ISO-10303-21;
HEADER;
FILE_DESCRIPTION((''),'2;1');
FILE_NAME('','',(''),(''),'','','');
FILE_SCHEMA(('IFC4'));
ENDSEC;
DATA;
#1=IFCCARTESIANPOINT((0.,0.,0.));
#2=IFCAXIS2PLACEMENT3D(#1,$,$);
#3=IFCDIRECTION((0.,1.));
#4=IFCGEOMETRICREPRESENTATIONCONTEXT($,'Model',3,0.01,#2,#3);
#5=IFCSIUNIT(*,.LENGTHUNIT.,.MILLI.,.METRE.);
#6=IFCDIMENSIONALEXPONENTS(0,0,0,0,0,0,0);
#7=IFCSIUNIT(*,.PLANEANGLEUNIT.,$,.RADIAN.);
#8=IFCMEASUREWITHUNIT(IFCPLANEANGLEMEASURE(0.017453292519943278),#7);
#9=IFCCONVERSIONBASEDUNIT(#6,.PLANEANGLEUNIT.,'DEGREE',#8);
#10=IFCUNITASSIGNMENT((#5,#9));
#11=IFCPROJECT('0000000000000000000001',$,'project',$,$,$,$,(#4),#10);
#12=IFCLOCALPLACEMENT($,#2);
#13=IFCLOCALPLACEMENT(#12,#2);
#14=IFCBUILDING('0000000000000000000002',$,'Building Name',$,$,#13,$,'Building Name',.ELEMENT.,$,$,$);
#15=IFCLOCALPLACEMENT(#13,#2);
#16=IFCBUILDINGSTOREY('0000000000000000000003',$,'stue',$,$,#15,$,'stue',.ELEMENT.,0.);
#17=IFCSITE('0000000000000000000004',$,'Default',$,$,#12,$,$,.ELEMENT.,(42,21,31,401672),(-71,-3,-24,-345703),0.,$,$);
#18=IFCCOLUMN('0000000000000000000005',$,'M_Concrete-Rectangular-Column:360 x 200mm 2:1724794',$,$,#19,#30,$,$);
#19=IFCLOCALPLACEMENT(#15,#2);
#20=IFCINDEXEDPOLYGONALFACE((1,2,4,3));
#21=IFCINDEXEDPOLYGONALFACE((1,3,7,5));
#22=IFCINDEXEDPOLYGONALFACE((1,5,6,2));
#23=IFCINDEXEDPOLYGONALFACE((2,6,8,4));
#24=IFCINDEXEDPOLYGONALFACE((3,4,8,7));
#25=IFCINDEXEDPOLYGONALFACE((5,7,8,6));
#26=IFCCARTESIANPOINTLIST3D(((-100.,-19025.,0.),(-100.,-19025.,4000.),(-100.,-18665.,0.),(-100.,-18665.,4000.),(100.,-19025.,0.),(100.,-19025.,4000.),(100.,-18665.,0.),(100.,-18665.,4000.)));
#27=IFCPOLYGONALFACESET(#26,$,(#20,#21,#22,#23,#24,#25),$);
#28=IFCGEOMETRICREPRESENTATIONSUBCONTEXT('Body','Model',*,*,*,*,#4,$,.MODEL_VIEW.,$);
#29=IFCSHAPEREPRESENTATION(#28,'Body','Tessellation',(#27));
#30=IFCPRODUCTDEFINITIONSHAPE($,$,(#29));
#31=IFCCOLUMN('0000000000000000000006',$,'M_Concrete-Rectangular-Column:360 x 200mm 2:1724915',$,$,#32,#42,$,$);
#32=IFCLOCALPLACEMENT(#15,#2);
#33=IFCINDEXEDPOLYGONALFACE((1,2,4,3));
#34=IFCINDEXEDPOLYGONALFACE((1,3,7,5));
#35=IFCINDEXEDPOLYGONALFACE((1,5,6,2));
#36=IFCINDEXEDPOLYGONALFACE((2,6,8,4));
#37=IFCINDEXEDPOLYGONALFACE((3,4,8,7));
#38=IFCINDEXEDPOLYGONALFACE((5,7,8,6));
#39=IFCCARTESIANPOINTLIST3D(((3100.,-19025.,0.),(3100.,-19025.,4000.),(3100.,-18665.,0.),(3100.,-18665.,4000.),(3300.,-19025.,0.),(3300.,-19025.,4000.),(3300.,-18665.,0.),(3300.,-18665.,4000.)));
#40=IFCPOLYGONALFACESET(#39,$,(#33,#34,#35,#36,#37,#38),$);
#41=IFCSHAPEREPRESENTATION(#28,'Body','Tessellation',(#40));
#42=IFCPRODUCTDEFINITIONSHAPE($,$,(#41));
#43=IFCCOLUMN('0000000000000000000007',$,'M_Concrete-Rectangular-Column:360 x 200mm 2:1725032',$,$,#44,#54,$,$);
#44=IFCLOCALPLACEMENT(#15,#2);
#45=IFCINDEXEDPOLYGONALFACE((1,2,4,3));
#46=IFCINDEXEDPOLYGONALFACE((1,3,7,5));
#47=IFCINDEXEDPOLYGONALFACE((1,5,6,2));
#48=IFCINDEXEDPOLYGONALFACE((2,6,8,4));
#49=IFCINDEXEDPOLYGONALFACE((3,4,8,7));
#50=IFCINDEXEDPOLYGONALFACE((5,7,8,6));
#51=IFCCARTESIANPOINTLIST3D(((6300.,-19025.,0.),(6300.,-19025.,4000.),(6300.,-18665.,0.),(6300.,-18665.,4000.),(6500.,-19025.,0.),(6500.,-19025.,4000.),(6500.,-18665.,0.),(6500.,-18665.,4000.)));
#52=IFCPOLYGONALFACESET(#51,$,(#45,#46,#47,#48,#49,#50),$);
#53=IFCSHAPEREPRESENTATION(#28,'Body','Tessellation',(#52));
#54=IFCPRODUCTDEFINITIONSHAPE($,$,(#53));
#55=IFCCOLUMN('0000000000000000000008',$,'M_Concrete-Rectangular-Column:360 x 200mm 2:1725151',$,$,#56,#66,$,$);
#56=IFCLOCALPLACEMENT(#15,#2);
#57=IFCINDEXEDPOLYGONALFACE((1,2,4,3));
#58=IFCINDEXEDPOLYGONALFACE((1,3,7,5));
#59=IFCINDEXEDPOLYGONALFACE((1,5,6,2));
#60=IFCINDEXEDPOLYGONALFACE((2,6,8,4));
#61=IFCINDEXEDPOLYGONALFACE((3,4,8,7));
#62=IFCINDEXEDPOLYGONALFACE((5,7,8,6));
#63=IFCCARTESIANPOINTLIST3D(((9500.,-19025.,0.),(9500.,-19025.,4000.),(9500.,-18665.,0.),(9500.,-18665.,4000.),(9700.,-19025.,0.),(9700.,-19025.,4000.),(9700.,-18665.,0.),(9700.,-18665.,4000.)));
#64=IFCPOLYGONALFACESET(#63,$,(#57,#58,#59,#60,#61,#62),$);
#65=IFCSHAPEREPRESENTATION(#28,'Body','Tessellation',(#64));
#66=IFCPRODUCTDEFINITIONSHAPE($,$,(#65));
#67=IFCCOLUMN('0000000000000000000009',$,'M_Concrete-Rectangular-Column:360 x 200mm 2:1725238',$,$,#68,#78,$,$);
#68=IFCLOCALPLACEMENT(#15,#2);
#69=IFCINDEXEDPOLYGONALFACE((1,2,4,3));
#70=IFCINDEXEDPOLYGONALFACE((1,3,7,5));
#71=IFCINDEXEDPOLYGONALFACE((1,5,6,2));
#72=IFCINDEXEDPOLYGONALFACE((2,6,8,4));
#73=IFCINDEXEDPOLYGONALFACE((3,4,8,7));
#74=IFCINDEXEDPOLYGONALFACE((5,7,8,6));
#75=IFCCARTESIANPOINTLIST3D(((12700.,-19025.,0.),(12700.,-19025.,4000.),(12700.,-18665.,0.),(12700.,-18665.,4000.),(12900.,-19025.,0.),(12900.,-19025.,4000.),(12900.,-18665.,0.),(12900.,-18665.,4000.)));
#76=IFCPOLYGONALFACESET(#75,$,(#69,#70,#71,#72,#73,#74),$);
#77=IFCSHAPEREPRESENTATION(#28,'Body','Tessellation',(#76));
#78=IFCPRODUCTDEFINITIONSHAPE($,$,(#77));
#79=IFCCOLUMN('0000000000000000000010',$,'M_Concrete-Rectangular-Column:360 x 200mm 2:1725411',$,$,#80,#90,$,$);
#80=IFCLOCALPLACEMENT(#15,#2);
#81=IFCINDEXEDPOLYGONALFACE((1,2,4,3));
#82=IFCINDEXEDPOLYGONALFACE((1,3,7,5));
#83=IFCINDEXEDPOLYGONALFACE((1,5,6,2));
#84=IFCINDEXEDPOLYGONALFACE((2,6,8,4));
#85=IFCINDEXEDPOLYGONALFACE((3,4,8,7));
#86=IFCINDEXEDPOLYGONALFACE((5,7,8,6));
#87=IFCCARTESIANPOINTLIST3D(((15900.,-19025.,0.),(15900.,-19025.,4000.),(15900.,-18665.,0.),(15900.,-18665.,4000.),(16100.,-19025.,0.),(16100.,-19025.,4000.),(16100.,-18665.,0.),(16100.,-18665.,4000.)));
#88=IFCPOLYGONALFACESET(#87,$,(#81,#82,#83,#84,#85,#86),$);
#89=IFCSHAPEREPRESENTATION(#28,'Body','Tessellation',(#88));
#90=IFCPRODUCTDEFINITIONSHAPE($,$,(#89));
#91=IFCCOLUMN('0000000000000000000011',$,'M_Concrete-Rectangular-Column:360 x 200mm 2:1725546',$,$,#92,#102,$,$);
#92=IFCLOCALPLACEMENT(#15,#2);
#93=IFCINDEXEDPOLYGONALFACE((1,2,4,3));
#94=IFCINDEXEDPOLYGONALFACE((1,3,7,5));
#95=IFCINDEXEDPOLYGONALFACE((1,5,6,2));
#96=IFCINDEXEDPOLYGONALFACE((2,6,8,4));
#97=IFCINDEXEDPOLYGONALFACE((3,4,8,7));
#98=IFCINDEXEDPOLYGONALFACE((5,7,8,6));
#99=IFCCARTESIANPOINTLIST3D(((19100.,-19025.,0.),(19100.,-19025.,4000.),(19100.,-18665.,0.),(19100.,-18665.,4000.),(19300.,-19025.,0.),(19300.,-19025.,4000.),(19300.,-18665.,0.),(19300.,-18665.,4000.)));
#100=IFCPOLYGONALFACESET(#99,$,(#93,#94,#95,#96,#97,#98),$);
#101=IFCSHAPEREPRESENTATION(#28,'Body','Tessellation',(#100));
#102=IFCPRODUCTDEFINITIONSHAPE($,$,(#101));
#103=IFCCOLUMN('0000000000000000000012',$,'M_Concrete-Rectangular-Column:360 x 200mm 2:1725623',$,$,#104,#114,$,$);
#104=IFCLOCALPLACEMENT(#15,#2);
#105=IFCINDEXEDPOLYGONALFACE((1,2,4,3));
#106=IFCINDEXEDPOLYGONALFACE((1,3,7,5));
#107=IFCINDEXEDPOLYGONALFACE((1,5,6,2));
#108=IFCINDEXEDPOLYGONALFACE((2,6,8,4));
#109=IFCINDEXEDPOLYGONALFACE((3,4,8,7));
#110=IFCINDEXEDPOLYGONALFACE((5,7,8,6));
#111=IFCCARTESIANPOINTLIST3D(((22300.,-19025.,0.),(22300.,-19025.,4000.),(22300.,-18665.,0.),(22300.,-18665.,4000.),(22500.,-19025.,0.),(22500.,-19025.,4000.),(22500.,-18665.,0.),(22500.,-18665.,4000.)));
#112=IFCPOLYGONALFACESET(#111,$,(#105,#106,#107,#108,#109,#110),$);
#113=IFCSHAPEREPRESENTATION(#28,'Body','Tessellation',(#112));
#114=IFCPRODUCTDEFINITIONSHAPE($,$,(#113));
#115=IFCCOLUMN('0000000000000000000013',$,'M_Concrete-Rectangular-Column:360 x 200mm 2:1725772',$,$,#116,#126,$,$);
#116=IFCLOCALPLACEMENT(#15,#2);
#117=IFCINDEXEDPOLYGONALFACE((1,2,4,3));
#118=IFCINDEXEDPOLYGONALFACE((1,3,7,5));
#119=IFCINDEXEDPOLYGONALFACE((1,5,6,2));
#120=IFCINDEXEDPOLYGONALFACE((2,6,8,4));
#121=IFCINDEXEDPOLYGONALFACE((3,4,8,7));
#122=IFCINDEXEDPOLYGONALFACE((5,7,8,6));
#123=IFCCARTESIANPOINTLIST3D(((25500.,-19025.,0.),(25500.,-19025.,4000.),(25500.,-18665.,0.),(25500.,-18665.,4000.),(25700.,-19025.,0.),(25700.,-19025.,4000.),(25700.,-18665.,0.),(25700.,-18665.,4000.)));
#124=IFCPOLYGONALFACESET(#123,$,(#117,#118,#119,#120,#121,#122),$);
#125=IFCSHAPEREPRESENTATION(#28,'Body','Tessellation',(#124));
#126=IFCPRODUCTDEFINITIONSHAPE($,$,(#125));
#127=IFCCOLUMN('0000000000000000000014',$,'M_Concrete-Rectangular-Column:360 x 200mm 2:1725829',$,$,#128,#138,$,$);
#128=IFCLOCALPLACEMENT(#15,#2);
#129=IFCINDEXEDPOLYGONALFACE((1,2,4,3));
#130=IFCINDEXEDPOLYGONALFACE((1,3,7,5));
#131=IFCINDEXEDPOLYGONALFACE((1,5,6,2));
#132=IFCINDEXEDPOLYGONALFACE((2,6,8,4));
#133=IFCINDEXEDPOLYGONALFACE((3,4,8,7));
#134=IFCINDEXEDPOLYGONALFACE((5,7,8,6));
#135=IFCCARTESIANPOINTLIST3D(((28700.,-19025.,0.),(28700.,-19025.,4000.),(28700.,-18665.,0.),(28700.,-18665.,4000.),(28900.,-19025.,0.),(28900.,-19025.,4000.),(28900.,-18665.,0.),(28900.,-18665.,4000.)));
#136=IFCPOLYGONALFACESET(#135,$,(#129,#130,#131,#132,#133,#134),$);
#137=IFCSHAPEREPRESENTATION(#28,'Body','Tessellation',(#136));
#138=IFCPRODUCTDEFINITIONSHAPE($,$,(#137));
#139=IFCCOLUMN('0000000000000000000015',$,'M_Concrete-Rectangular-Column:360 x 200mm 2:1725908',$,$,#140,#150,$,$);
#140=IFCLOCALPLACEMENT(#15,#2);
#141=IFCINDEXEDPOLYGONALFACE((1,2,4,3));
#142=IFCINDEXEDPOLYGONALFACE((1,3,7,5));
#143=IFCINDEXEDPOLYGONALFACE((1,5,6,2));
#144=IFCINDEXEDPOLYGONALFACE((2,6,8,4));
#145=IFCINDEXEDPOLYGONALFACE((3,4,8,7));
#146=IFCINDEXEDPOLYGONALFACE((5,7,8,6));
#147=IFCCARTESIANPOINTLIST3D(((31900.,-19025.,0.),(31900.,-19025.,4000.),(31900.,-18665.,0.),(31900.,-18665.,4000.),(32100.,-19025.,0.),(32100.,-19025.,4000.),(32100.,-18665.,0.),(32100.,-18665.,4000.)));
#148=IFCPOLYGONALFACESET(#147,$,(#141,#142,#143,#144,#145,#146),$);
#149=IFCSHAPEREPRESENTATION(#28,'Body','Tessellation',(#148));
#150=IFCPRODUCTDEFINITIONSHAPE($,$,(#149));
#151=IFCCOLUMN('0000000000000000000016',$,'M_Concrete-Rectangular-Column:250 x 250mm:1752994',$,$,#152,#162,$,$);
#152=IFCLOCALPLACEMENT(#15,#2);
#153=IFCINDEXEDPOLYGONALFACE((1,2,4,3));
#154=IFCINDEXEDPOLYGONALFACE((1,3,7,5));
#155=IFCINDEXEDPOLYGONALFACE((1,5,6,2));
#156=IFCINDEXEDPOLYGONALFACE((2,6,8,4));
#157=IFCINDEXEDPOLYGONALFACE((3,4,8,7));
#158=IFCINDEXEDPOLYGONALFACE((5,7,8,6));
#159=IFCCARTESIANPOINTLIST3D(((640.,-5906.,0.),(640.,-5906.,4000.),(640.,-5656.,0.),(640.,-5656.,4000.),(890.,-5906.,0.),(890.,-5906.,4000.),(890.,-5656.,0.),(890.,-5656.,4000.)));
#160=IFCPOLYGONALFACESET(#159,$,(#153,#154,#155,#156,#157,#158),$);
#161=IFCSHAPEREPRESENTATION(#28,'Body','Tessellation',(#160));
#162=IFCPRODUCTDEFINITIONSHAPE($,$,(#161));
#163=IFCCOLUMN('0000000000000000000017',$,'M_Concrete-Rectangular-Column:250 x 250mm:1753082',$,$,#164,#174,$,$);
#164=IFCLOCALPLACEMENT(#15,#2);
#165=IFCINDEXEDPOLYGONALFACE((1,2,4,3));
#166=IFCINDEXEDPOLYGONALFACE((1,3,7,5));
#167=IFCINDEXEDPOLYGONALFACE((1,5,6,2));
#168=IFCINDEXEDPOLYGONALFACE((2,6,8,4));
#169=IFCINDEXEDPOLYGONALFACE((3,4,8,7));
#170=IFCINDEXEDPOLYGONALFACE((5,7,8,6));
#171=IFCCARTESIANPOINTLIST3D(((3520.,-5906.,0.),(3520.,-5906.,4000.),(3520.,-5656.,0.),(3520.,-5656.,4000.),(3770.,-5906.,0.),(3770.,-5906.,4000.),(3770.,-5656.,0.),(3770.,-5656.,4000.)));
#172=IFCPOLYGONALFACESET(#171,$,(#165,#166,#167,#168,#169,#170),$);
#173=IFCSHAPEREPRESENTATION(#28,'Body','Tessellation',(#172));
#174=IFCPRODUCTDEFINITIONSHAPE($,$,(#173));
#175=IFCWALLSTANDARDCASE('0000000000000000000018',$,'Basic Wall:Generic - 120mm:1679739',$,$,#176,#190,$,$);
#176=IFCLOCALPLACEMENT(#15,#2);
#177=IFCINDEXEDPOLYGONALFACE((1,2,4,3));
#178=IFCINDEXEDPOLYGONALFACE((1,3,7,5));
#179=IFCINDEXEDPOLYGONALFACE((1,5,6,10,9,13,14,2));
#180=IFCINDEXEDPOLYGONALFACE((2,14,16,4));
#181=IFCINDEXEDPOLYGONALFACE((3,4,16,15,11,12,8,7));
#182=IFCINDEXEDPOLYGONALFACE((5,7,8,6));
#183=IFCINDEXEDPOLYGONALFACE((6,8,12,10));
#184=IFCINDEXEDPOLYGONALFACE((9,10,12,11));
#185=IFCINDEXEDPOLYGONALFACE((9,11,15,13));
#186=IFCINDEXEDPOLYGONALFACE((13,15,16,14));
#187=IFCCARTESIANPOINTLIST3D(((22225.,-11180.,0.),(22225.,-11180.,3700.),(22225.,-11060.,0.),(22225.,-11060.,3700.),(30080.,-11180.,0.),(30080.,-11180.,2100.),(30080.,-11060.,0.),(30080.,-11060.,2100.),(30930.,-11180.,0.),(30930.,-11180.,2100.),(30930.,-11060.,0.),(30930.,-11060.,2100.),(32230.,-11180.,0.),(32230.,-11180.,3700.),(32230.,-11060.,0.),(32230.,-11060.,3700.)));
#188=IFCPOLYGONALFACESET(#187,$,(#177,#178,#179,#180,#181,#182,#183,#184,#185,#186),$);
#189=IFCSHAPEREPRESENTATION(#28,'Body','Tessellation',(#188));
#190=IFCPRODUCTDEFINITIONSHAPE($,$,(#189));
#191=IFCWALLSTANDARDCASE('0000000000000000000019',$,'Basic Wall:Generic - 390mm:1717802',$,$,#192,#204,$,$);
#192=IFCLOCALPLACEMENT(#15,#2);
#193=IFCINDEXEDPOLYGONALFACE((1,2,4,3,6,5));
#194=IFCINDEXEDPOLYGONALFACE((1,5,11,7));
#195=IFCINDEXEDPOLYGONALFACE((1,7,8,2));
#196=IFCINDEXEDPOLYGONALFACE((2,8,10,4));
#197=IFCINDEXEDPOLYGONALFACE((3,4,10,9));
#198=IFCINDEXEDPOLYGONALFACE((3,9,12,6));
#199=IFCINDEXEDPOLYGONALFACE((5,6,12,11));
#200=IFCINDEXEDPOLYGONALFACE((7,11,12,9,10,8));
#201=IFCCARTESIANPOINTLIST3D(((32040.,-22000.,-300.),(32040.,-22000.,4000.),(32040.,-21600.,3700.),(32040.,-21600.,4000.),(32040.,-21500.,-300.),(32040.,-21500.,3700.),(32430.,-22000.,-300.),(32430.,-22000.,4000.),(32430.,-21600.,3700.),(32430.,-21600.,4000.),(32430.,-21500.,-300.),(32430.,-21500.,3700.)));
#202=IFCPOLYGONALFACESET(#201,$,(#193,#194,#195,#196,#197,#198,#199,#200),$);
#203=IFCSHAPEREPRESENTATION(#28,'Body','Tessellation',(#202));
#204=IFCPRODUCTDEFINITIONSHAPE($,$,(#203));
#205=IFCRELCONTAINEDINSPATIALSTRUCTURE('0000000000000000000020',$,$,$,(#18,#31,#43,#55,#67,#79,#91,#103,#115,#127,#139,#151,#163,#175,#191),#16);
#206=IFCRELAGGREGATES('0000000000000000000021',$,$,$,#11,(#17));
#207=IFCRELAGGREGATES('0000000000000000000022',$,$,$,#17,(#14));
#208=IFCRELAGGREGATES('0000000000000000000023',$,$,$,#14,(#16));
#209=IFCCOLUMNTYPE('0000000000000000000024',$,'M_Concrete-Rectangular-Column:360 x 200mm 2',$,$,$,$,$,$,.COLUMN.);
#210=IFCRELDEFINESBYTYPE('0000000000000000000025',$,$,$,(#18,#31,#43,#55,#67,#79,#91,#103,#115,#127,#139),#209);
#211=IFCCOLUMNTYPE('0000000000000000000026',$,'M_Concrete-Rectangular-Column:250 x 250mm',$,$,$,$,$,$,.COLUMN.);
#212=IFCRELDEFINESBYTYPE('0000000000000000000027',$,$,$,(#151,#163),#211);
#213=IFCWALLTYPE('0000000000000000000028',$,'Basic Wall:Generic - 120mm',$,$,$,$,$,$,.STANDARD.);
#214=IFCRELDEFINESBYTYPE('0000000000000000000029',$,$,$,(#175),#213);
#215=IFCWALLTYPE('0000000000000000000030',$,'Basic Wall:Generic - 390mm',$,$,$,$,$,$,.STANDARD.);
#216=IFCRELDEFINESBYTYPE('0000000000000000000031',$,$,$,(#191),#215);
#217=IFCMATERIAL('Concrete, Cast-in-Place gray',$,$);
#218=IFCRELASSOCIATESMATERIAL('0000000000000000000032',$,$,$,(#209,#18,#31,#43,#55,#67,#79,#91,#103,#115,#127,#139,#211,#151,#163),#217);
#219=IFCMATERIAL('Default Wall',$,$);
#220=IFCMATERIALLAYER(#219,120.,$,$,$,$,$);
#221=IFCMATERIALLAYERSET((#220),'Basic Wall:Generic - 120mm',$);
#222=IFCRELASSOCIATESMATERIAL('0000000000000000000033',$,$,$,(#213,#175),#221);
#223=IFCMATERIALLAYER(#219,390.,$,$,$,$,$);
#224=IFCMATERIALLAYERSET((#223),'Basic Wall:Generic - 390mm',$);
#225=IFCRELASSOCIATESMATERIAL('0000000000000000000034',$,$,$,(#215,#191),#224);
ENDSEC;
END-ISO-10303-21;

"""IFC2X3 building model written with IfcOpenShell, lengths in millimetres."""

from ifc_helpers import new_model, entity, si_unit, converted_unit, direction, frame, frame_2d, origin, origin_2d_with_axis, place, context, subcontext, project, spatial, polyline, rectangle, extrude, clip, bounded_halfspace, source, transform, mapped, material, layer, layer_set, layer_usage, type_object, type_shapes, element, save


model = new_model("IFC2X3")

# Units and contexts
model_context = context("Model", 3, precision=0.01, world=origin(), true_north=direction((0.0, 1.0)))
body_context = subcontext(model_context, "Body", "Model", "MODEL_VIEW")
ifc_project = project(units=[si_unit("LENGTHUNIT", "METRE", prefix="MILLI"), converted_unit("PLANEANGLEUNIT", "DEGREE", entity("IfcPlaneAngleMeasure", 0.017453292519943278), si_unit("PLANEANGLEUNIT", "RADIAN"), dimensions=[0, 0, 0, 0, 0, 0, 0])], contexts=[model_context])

# Site, building, storey
site_placement = place(None, origin())
site = spatial("IfcSite", under=ifc_project, at=site_placement, Name="Default", CompositionType="ELEMENT", RefLatitude=(42, 21, 31, 401672), RefLongitude=(-71, -3, -24, -345703), RefElevation=0.0)
building_placement = place(site_placement, origin())
building = spatial("IfcBuilding", under=site, at=building_placement, Name="Building Name", LongName="Building Name", CompositionType="ELEMENT")
storey_placement = place(building_placement, origin())
storey = spatial("IfcBuildingStorey", under=building, at=storey_placement, Name="stue", LongName="stue", CompositionType="ELEMENT", Elevation=0.0)

# Columns
ifc_material_1 = material(Name="Concrete, Cast-in-Place gray")
column_type_1 = type_object("IfcColumnType", Name="M_Concrete-Rectangular-Column:360 x 200mm 2", PredefinedType="COLUMN", material=ifc_material_1)
shared_shape_1 = source(origin(), body_context, "Body", "SweptSolid", [
    extrude(rectangle(XDim=200.0, YDim=360.0, at=origin_2d_with_axis()), frame((0.0, 0.0, 0.0), z_axis=(0.0, 0.0, 1.0), x_axis=(-1.0, 0.0, 0.0)), (0.0, 0.0, 1.0), 4000.0),
])
type_shapes(column_type_1, [shared_shape_1])
for number, where, name in (
    (1, (0.0, -18845.0, 0.0), "M_Concrete-Rectangular-Column:360 x 200mm 2:1724794"),
    (2, (3200.0, -18845.0, 0.0), "M_Concrete-Rectangular-Column:360 x 200mm 2:1724915"),
    (3, (6400.0, -18845.0, 0.0), "M_Concrete-Rectangular-Column:360 x 200mm 2:1725032"),
    (4, (9600.0, -18845.0, 0.0), "M_Concrete-Rectangular-Column:360 x 200mm 2:1725151"),
    (5, (12800.0, -18845.0, 0.0), "M_Concrete-Rectangular-Column:360 x 200mm 2:1725238"),
    (6, (16000.0, -18845.0, 0.0), "M_Concrete-Rectangular-Column:360 x 200mm 2:1725411"),
    (7, (19200.0, -18845.0, 0.0), "M_Concrete-Rectangular-Column:360 x 200mm 2:1725546"),
    (8, (22400.0, -18845.0, 0.0), "M_Concrete-Rectangular-Column:360 x 200mm 2:1725623"),
    (9, (25600.0, -18845.0, 0.0), "M_Concrete-Rectangular-Column:360 x 200mm 2:1725772"),
    (10, (28800.0, -18845.0, 0.0), "M_Concrete-Rectangular-Column:360 x 200mm 2:1725829"),
    (11, (32000.0, -18845.0, 0.0), "M_Concrete-Rectangular-Column:360 x 200mm 2:1725908"),
):
    element("IfcColumn", number, at=place(storey_placement, frame(where)), inside=storey, type_object=column_type_1, material=ifc_material_1, Name=name, context=body_context, shape_type="MappedRepresentation", body=[
        mapped(shared_shape_1, transform((0.0, 0.0, 0.0), scale=1.0)),
    ])
column_type_2 = type_object("IfcColumnType", Name="M_Concrete-Rectangular-Column:250 x 250mm", PredefinedType="COLUMN", material=ifc_material_1)
shared_shape_2 = source(origin(), body_context, "Body", "SweptSolid", [
    extrude(rectangle(XDim=250.0, YDim=250.0, at=origin_2d_with_axis()), frame((0.0, 0.0, 0.0), z_axis=(0.0, 0.0, 1.0), x_axis=(-1.0, 0.0, 0.0)), (0.0, 0.0, 1.0), 4000.0),
])
type_shapes(column_type_2, [shared_shape_2])
for number, where, name in (
    (12, (765.0, -5781.0, 0.0), "M_Concrete-Rectangular-Column:250 x 250mm:1752994"),
    (13, (3645.0, -5781.0, 0.0), "M_Concrete-Rectangular-Column:250 x 250mm:1753082"),
):
    element("IfcColumn", number, at=place(storey_placement, frame(where)), inside=storey, type_object=column_type_2, material=ifc_material_1, Name=name, context=body_context, shape_type="MappedRepresentation", body=[
        mapped(shared_shape_2, transform((0.0, 0.0, 0.0), scale=1.0)),
    ])

# Wall, opening
ifc_material_2 = material(Name="Default Wall")
ifc_layer_1 = layer(ifc_material_2, 120.0)
ifc_layer_set_1 = layer_set([ifc_layer_1], Name="Basic Wall:Generic - 120mm")
ifc_layer_usage_1 = layer_usage(ifc_layer_set_1, "AXIS2", "NEGATIVE", 60.0)
wall_type_1 = type_object("IfcWallType", Name="Basic Wall:Generic - 120mm", PredefinedType="STANDARD", material=ifc_layer_set_1)
wall_1_placement = place(storey_placement, frame((22225.0, -11120.0, 0.0)))
wall_1 = element("IfcWallStandardCase", 14, at=wall_1_placement, inside=storey, type_object=wall_type_1, material=ifc_layer_usage_1, Name="Basic Wall:Generic - 120mm:1679739", context=body_context, shape_type="Clipping", body=[
    clip(clip(extrude(rectangle(XDim=120.0, YDim=10005.0, at=frame_2d((5002.5, 0.0), x_axis=(0.0, 1.0))), origin(), (0.0, 0.0, 1.0), 3700.0), bounded_halfspace(frame((270.0, -60.0, 3700.0), z_axis=(0.0, 0.0, -1.0), x_axis=(0.0, 1.0, 0.0)), True, frame((270.0, -60.0, 3700.0)), polyline([(0.0, 0.0), (9735.0, 0.0), (9735.0, 120.0), (0.0, 120.0), (0.0, 0.0)]))), bounded_halfspace(frame((0.0, -60.0, 3700.0), z_axis=(0.0, 0.0, -1.0), x_axis=(0.0, -1.0, 0.0)), True, frame((0.0, -60.0, 3700.0)), polyline([(0.0, 0.0), (270.0, 0.0), (270.0, 120.0), (120.0, 120.0), (0.0, 120.0), (0.0, 0.0)]))),
])
opening_1_placement = place(wall_1_placement, frame((7855.0, -60.0, 0.0)))
element("IfcOpeningElement", 15, at=opening_1_placement, cuts=wall_1, ObjectType="Opening", context=body_context, shape_type="SweptSolid", body=[
    extrude(rectangle(XDim=2100.0, YDim=850.0, at=frame_2d((1050.0, 425.0), x_axis=(1.0, 0.0))), frame((0.0, 0.0, 0.0), z_axis=(0.0, 1.0, 0.0), x_axis=(0.0, 0.0, 1.0)), (0.0, 0.0, 1.0), 120.0),
])

# Wall
ifc_layer_2 = layer(ifc_material_2, 390.0)
ifc_layer_set_2 = layer_set([ifc_layer_2], Name="Basic Wall:Generic - 390mm")
ifc_layer_usage_2 = layer_usage(ifc_layer_set_2, "AXIS2", "NEGATIVE", 195.0)
wall_type_2 = type_object("IfcWallType", Name="Basic Wall:Generic - 390mm", PredefinedType="STANDARD", material=ifc_layer_set_2)
wall_2_placement = place(storey_placement, frame((32235.0, -21500.0, -300.0), z_axis=(0.0, 0.0, 1.0), x_axis=(0.0, -1.0, 0.0)))
element("IfcWallStandardCase", 16, at=wall_2_placement, inside=storey, type_object=wall_type_2, material=ifc_layer_usage_2, Name="Basic Wall:Generic - 390mm:1717802", context=body_context, shape_type="Clipping", body=[
    clip(extrude(rectangle(XDim=500.0, YDim=390.0, at=frame_2d((250.0, 0.0), x_axis=(-1.0, 0.0))), origin(), (0.0, 0.0, 1.0), 4300.0), bounded_halfspace(frame((0.0, -195.0, 4000.0), z_axis=(0.0, 0.0, -1.0), x_axis=(0.0, -1.0, 0.0)), True, frame((0.0, -195.0, 4000.0)), polyline([(0.0, 0.0), (100.0, 0.0), (100.0, 390.0), (0.0, 390.0), (0.0, 0.0)]))),
])

save(model, "model.ifc")
